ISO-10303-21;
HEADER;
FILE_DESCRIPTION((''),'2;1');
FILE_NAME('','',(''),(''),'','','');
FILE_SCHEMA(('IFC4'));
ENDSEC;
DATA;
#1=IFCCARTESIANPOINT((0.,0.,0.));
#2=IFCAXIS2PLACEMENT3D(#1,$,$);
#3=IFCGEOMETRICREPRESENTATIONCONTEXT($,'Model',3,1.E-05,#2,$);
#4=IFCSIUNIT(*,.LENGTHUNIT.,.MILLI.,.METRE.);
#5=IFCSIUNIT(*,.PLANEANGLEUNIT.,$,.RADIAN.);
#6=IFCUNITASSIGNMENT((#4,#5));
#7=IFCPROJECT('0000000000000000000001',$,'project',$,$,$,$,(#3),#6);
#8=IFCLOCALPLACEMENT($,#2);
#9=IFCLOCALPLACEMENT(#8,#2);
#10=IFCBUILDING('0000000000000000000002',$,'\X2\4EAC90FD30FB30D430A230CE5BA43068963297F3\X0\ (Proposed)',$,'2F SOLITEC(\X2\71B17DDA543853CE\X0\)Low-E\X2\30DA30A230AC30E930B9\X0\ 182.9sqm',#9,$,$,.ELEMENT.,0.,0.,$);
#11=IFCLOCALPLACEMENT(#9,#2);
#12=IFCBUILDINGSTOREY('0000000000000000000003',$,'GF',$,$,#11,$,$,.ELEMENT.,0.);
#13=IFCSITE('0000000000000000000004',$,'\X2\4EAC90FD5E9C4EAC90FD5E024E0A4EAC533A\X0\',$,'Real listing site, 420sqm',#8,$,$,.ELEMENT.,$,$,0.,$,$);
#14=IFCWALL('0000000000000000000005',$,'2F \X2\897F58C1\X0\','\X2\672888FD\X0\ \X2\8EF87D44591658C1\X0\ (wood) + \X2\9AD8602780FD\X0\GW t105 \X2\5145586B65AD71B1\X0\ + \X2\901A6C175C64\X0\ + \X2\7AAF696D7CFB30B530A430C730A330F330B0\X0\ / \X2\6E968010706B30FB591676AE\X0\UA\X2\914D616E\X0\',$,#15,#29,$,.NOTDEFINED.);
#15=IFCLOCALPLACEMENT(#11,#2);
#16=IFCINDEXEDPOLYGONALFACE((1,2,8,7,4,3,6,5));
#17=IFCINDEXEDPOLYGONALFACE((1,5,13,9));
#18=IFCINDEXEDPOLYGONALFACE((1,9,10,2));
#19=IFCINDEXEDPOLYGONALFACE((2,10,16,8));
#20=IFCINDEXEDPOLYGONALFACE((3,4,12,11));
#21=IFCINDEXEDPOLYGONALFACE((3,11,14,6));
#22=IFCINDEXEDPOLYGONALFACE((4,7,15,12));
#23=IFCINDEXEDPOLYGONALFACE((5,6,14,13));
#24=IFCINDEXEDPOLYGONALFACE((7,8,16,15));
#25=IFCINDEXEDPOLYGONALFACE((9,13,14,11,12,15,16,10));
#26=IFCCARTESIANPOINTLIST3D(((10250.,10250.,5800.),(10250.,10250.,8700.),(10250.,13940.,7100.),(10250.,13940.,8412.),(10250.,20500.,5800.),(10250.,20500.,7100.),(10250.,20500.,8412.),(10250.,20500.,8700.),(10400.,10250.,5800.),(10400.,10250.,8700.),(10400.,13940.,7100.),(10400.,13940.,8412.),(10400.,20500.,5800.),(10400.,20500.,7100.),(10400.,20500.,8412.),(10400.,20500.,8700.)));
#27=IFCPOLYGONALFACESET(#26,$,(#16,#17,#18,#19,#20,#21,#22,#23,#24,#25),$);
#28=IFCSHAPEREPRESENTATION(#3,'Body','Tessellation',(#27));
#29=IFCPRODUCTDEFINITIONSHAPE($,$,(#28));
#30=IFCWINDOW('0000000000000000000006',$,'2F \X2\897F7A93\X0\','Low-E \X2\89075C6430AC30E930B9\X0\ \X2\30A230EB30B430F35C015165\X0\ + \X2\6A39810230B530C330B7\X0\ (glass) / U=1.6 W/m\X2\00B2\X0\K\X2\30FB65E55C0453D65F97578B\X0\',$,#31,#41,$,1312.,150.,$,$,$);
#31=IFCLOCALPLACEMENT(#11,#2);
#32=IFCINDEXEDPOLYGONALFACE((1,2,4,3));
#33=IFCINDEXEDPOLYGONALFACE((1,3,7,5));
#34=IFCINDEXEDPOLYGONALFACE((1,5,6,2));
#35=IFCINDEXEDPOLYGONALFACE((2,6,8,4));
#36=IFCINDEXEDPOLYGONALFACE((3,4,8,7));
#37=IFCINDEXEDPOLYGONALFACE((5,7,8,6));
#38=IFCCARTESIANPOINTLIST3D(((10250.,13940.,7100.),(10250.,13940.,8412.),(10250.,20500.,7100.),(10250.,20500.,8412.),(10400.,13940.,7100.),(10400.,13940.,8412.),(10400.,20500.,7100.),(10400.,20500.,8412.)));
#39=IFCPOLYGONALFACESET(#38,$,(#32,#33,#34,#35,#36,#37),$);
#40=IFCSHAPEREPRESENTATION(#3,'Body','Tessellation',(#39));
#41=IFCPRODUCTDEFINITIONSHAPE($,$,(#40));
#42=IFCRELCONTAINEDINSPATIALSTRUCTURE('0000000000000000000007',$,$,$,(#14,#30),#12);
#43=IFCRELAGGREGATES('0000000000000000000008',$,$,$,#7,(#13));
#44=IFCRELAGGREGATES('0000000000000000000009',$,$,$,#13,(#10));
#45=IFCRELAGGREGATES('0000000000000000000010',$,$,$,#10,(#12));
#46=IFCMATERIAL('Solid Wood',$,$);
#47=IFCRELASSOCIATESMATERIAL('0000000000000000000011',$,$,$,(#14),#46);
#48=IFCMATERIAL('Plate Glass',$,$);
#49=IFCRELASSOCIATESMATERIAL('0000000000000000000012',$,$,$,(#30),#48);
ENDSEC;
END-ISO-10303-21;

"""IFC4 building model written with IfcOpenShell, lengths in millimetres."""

from ifc_helpers import new_model, si_unit, frame, frame_2d, origin, place, context, project, spatial, rectangle, extrude, material, element, fill, save


model = new_model("IFC4")

# Units and contexts
model_context = context("Model", 3, precision=1e-05, world=origin())
ifc_project = project(units=[si_unit("LENGTHUNIT", "METRE", prefix="MILLI"), si_unit("PLANEANGLEUNIT", "RADIAN")], contexts=[model_context])

# Site, building, storey
site_placement = place(None, origin())
site = spatial("IfcSite", under=ifc_project, at=site_placement, Name="京都府京都市上京区", ObjectType="Real listing site, 420sqm", CompositionType="ELEMENT", RefElevation=0.0)
building_placement = place(site_placement, origin())
building = spatial("IfcBuilding", under=site, at=building_placement, Name="京都・ピアノ室と防音 (Proposed)", ObjectType="2F SOLITEC(熱線吸収)Low-Eペアガラス 182.9sqm", CompositionType="ELEMENT", ElevationOfRefHeight=0.0, ElevationOfTerrain=0.0)
storey_placement = place(building_placement, origin())
storey = spatial("IfcBuildingStorey", under=building, at=storey_placement, Name="GF", CompositionType="ELEMENT", Elevation=0.0)

# Shared definitions
ifc_material_1 = material(Name="Solid Wood")

# Shared definitions
ifc_material_2 = material(Name="Plate Glass")

# Wall, opening, window
wall_1_placement = place(storey_placement, frame((5125.0, 5125.0, 2900.0)))
wall_1 = element("IfcWall", 1, at=wall_1_placement, inside=storey, material=ifc_material_1, Name="2F 西壁", Description="木製 軸組外壁 (wood) + 高性能GW t105 充填断熱 + 通気層 + 窯業系サイディング / 準耐火・外皮UA配慮", PredefinedType="NOTDEFINED", context=model_context, shape_type="SweptSolid", body=[
    extrude(rectangle(XDim=150.0, YDim=10250.0, at=frame_2d((75.0, 5125.0))), frame((5125.0, 5125.0, 2900.0)), (0.0, 0.0, 1.0), 2900.0),
])
opening_1_placement = place(storey_placement, frame((5125.0, 6970.0, 3550.0)))
opening_1 = element("IfcOpeningElement", 2, at=opening_1_placement, cuts=wall_1, PredefinedType="NOTDEFINED", context=model_context, shape_type="SweptSolid", body=[
    extrude(rectangle(XDim=150.0, YDim=6560.0, at=frame_2d((75.0, 3280.0))), frame((5125.0, 6970.0, 3550.0)), (0.0, 0.0, 1.0), 1312.0),
])
window_1_placement = place(storey_placement, frame((5125.0, 6970.0, 3550.0)))
window_1 = element("IfcWindow", 3, at=window_1_placement, inside=storey, material=ifc_material_2, Name="2F 西窓", Description="Low-E 複層ガラス アルゴン封入 + 樹脂サッシ (glass) / U=1.6 W/m²K・日射取得型", OverallHeight=1312.0, OverallWidth=150.0, context=model_context, shape_type="SweptSolid", body=[
    extrude(rectangle(XDim=150.0, YDim=6560.0, at=frame_2d((75.0, 3280.0))), frame((5125.0, 6970.0, 3550.0)), (0.0, 0.0, 1.0), 1312.0),
])
fill(opening_1, window_1)

save(model, "model.ifc")
